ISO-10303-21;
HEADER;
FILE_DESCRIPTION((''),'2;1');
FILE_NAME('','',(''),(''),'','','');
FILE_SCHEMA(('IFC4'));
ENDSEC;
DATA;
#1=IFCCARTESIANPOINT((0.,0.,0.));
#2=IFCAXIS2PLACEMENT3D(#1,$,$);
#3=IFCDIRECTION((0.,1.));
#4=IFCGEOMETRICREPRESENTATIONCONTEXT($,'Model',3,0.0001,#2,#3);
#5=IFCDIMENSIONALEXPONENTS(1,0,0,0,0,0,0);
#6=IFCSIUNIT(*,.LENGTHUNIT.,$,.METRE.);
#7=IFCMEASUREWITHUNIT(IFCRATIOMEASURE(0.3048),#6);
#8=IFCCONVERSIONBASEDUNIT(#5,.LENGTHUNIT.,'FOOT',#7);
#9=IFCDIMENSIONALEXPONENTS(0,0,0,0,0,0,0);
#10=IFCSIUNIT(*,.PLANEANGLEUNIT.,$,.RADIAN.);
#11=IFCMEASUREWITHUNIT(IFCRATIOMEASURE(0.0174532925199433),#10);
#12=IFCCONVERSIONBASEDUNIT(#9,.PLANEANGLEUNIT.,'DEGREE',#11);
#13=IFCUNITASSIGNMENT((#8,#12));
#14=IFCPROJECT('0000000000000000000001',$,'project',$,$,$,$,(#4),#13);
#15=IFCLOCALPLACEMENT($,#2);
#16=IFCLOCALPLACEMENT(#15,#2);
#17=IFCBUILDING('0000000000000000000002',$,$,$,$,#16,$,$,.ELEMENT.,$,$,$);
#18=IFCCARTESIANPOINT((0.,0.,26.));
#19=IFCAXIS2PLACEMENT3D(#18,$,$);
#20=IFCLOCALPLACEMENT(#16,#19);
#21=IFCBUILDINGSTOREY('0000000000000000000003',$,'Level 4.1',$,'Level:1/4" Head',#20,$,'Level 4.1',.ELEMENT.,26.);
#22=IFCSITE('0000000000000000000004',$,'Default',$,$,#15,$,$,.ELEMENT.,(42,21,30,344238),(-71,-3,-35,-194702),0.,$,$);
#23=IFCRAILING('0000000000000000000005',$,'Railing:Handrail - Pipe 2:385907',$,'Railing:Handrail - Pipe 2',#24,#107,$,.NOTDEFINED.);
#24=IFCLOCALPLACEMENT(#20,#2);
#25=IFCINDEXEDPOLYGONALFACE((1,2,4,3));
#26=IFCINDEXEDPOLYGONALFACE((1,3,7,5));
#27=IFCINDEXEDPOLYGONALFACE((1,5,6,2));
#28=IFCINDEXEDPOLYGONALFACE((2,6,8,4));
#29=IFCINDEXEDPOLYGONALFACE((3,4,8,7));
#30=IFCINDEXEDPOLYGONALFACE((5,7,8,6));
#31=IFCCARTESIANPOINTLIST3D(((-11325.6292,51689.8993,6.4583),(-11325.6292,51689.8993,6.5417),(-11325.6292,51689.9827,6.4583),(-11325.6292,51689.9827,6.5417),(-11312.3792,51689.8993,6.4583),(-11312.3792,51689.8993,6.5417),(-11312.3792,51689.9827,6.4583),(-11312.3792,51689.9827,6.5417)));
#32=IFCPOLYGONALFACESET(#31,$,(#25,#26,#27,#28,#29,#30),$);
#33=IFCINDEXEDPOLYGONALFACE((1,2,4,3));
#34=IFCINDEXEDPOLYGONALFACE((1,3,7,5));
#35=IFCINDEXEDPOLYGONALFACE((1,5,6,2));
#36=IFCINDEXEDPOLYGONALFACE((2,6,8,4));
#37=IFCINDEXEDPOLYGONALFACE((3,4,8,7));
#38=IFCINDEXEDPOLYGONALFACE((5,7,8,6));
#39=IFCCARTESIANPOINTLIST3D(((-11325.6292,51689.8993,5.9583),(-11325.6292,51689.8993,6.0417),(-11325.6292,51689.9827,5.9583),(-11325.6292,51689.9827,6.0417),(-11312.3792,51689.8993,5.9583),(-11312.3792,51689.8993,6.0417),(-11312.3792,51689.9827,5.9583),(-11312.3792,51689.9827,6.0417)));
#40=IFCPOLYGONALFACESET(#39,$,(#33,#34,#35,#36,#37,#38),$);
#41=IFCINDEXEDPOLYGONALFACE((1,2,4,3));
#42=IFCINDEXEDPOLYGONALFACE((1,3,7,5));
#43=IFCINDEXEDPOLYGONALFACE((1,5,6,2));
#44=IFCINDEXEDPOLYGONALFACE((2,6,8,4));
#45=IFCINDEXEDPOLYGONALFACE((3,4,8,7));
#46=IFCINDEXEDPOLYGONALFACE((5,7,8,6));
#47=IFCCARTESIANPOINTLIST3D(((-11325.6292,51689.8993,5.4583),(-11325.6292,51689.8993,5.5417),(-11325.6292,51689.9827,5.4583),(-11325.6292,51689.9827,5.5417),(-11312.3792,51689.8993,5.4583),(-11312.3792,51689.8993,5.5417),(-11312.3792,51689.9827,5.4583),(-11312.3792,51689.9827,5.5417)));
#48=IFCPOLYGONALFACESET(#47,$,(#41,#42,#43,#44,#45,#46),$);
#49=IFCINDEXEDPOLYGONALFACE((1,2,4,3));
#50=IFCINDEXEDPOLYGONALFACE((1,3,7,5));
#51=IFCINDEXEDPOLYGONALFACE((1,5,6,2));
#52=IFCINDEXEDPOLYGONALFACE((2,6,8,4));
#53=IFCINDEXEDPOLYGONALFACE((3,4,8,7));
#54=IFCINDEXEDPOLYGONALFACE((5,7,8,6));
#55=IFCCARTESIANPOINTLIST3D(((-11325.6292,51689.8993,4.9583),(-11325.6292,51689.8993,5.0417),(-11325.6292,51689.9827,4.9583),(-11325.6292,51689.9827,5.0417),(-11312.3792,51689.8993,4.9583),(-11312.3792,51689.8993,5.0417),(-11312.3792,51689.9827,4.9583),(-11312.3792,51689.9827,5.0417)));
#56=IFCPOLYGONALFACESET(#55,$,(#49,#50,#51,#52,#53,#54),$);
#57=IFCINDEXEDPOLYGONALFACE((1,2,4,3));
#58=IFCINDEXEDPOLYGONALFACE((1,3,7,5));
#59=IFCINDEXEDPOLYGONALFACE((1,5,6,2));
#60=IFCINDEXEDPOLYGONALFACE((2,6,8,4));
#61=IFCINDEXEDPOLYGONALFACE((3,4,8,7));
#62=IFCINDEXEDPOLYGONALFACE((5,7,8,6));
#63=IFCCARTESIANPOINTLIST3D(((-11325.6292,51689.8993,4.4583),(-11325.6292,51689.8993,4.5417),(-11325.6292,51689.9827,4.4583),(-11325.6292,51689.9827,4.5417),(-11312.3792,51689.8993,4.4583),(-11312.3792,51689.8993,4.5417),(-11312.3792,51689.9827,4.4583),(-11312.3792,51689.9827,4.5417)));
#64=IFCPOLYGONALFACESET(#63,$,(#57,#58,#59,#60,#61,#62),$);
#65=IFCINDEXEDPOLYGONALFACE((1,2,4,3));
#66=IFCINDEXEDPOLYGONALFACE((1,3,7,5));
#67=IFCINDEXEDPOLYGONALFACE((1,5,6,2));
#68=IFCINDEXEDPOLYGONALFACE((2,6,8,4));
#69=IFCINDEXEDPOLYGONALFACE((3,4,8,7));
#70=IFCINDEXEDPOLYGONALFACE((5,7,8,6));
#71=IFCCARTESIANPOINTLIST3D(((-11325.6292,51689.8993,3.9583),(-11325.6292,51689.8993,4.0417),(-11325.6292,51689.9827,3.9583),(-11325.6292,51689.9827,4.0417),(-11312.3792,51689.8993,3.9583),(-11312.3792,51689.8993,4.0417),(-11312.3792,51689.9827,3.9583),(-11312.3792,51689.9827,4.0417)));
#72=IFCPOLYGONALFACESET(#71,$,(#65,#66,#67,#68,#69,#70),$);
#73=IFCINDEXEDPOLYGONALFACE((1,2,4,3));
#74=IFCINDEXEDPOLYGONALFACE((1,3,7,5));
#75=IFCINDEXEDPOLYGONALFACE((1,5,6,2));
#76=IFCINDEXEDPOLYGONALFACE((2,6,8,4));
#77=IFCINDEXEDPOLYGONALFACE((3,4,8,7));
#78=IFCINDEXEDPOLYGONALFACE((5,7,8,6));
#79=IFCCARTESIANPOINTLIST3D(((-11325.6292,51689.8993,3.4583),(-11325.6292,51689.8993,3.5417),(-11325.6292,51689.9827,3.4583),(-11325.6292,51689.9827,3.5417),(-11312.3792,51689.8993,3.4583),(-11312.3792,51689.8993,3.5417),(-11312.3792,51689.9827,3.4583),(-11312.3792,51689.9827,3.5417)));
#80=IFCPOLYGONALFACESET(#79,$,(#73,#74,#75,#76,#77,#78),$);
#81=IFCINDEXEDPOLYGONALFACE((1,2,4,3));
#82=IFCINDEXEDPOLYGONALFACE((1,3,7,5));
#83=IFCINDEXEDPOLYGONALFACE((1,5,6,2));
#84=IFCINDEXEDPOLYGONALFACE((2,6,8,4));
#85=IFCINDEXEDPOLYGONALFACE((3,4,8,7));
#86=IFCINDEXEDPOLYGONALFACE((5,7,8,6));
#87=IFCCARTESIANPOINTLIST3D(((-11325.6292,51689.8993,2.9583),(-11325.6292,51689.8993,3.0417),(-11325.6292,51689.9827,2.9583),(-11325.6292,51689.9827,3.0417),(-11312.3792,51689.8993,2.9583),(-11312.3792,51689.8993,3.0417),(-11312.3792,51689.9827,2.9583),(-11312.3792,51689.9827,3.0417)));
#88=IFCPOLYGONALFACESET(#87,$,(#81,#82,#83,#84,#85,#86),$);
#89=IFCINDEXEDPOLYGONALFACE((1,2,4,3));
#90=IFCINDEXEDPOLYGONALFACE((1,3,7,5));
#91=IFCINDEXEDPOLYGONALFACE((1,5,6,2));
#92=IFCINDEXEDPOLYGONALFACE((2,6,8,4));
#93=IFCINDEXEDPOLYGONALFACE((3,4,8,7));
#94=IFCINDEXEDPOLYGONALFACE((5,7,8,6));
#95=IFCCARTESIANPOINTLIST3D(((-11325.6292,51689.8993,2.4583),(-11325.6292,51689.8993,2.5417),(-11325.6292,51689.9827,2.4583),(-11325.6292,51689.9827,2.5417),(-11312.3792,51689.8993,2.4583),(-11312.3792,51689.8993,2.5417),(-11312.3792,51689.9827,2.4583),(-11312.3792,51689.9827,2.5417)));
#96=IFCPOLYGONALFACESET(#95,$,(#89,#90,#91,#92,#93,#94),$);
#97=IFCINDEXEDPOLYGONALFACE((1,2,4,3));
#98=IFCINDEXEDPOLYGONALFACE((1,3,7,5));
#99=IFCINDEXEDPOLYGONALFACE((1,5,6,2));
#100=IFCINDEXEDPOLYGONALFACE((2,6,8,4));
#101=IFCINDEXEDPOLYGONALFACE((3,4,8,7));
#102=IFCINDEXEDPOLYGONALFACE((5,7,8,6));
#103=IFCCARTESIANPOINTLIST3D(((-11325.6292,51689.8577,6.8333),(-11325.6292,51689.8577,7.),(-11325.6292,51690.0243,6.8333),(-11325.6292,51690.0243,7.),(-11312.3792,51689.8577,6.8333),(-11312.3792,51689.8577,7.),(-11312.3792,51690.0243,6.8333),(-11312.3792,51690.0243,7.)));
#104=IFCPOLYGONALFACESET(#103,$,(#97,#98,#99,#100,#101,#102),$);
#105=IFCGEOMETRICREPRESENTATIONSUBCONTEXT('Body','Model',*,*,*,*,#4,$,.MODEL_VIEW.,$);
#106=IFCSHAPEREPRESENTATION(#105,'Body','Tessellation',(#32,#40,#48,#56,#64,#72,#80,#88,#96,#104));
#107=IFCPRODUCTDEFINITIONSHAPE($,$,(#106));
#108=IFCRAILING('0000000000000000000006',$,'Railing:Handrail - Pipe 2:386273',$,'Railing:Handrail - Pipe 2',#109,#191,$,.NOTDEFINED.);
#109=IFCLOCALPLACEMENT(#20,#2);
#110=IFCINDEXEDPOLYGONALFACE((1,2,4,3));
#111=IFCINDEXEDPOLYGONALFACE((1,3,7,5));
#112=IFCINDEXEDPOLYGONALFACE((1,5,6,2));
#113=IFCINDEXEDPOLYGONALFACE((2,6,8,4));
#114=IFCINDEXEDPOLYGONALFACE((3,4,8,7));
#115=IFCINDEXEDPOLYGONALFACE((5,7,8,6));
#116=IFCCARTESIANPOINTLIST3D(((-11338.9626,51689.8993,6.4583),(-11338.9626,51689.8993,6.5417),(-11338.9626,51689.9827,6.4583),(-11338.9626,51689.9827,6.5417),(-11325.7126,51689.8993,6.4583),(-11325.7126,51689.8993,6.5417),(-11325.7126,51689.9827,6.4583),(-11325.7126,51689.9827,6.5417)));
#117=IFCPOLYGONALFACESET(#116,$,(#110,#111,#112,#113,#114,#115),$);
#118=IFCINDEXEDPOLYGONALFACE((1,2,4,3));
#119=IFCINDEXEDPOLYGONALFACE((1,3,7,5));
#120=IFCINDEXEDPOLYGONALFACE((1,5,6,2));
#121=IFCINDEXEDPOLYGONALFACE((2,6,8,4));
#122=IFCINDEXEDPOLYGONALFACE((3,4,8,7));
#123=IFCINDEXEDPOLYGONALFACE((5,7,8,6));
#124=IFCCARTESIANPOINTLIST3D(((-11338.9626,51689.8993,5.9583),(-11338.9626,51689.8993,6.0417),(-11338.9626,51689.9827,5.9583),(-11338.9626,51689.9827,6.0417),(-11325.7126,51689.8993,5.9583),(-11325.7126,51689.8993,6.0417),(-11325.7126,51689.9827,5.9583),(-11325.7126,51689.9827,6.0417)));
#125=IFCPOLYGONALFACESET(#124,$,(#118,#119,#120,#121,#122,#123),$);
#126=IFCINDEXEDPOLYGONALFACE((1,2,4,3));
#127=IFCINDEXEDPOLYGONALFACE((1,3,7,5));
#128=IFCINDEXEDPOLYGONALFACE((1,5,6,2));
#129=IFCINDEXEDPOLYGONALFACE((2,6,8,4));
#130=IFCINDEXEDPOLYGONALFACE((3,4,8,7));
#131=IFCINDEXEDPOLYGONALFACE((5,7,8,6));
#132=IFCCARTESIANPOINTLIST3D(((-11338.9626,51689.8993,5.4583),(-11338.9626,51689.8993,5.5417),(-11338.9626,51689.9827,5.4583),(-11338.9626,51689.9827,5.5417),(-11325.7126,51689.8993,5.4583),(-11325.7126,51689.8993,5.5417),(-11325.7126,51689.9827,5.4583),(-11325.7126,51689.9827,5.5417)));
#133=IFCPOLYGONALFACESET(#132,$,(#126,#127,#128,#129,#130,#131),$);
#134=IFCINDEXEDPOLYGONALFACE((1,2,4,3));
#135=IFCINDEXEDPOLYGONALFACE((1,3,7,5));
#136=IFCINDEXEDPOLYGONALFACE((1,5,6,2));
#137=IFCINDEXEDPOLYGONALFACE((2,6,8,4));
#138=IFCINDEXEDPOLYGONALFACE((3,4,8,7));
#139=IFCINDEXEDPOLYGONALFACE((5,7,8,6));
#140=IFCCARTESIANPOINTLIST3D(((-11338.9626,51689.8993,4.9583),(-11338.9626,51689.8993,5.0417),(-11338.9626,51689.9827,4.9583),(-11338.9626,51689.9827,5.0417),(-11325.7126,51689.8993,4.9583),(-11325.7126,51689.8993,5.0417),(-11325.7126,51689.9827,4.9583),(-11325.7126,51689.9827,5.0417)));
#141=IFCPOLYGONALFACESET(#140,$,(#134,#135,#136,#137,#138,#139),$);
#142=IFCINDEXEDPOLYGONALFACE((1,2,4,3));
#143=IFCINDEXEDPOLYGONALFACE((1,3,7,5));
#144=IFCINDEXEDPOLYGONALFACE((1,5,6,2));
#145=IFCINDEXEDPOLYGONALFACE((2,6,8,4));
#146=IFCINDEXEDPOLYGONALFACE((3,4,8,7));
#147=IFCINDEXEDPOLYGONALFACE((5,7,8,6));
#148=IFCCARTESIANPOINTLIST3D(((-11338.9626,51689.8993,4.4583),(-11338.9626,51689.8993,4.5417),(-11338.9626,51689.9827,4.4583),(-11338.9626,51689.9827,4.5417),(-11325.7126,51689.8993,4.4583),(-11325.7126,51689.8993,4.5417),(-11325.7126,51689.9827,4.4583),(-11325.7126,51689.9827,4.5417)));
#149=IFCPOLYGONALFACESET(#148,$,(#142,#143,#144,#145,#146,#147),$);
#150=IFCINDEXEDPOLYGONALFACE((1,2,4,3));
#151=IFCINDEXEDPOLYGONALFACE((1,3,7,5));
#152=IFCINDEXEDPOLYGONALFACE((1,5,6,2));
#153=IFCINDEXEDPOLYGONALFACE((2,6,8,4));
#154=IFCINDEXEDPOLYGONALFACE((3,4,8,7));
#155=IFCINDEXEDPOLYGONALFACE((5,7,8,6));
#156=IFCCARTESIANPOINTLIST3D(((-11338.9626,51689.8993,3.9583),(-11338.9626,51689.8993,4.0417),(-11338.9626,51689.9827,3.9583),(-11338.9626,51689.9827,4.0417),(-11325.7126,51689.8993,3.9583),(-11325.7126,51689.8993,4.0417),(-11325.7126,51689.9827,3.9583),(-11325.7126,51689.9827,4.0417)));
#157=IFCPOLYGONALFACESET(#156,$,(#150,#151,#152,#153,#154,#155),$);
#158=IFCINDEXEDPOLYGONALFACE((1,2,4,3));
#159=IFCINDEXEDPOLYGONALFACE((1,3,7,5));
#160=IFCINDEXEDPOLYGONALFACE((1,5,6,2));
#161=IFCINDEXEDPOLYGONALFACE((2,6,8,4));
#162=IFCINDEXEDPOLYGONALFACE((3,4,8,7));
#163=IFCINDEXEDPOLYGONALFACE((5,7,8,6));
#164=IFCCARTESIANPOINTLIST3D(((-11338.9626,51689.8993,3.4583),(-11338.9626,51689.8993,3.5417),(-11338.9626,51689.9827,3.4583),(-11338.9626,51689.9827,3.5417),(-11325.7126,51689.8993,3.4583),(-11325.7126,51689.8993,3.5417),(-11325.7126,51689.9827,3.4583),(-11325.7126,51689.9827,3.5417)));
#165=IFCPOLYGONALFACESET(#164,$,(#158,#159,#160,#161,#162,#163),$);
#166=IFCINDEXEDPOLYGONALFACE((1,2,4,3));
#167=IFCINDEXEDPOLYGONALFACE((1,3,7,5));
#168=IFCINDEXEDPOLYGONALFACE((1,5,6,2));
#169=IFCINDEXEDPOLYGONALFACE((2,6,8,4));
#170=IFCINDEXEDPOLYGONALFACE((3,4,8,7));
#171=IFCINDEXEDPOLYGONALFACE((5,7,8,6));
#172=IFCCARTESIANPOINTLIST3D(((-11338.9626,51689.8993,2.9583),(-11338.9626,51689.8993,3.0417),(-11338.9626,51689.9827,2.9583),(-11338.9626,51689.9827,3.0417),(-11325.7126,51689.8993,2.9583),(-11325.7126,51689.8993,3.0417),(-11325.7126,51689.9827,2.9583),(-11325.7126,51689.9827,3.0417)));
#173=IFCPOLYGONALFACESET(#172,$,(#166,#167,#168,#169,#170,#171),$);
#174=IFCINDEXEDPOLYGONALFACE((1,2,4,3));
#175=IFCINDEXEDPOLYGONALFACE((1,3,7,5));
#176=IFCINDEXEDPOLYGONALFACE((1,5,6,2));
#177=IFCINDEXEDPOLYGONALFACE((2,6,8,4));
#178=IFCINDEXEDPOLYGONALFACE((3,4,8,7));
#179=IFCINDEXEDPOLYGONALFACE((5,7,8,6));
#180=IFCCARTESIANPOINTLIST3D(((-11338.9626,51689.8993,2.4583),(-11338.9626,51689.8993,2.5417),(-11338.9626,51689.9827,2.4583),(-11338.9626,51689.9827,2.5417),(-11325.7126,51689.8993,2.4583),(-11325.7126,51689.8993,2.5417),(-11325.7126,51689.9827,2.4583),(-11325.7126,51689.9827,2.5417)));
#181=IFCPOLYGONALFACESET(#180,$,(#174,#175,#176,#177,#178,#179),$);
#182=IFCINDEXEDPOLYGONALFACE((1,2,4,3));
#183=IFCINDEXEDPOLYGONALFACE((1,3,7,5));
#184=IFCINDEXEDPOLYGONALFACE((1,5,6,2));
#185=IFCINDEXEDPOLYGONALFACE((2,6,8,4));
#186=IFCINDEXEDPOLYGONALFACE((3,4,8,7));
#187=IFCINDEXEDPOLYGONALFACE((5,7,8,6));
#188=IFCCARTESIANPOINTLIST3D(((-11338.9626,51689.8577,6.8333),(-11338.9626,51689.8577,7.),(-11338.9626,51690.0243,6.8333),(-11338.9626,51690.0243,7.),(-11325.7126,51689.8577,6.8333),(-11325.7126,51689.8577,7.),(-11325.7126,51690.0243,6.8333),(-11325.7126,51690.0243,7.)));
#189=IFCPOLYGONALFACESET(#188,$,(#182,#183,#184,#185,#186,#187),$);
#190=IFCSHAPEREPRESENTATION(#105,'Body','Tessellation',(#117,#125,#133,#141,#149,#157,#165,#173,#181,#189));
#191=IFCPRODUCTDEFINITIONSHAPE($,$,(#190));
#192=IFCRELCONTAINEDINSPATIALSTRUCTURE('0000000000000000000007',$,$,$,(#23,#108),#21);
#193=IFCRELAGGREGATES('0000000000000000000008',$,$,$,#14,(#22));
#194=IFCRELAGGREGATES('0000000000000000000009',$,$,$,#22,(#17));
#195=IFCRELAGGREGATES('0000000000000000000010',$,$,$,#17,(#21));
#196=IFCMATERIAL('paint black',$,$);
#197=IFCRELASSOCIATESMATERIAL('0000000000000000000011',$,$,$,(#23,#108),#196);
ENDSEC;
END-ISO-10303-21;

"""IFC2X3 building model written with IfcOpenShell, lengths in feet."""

from ifc_helpers import new_model, entity, si_unit, converted_unit, direction, frame, frame_2d, origin, place, context, subcontext, project, spatial, rectangle, extrude, material, element, save


model = new_model("IFC2X3")

# Units and contexts
model_context = context("Model", 3, precision=0.0001, world=origin(), true_north=direction((0.0, 1.0)))
body_context = subcontext(model_context, "Body", "Model", "MODEL_VIEW")
ifc_project = project(units=[converted_unit("LENGTHUNIT", "FOOT", entity("IfcRatioMeasure", 0.3048), si_unit("LENGTHUNIT", "METRE"), dimensions=[1, 0, 0, 0, 0, 0, 0]), converted_unit("PLANEANGLEUNIT", "DEGREE", entity("IfcRatioMeasure", 0.0174532925199433), si_unit("PLANEANGLEUNIT", "RADIAN"), dimensions=[0, 0, 0, 0, 0, 0, 0])], contexts=[model_context])

# Site, building, storey
site_placement = place(None, origin())
site = spatial("IfcSite", under=ifc_project, at=site_placement, Name="Default", CompositionType="ELEMENT", RefLatitude=(42, 21, 30, 344238), RefLongitude=(-71, -3, -35, -194702), RefElevation=0.0)
building_placement = place(site_placement, origin())
building = spatial("IfcBuilding", under=site, at=building_placement, CompositionType="ELEMENT")
storey_placement = place(building_placement, frame((0.0, 0.0, 26.0)))
storey = spatial("IfcBuildingStorey", under=building, at=storey_placement, Name="Level 4.1", ObjectType="Level:1/4\" Head", LongName="Level 4.1", CompositionType="ELEMENT", Elevation=26.0)

# Railings
ifc_material_1 = material(Name="paint black")
railing_1_placement = place(storey_placement, origin())
element("IfcRailing", 1, at=railing_1_placement, inside=storey, material=ifc_material_1, Name="Railing:Handrail - Pipe 2:385907", ObjectType="Railing:Handrail - Pipe 2", PredefinedType="NOTDEFINED", context=body_context, shape_type="SweptSolid", body=[
    extrude(rectangle(XDim=13.25, YDim=0.0833, at=frame_2d((0.0, 0.0), x_axis=(1.0, 0.0))), frame((-11319.0042, 51689.941, 6.4583), z_axis=(0.0, 0.0, 1.0), x_axis=(-1.0, 0.0, 0.0)), (0.0, 0.0, 1.0), 0.0833),
    extrude(rectangle(XDim=13.25, YDim=0.0833, at=frame_2d((0.0, 0.0), x_axis=(1.0, 0.0))), frame((-11319.0042, 51689.941, 5.9583), z_axis=(0.0, 0.0, 1.0), x_axis=(-1.0, 0.0, 0.0)), (0.0, 0.0, 1.0), 0.0833),
    extrude(rectangle(XDim=13.25, YDim=0.0833, at=frame_2d((0.0, 0.0), x_axis=(1.0, 0.0))), frame((-11319.0042, 51689.941, 5.4583), z_axis=(0.0, 0.0, 1.0), x_axis=(-1.0, 0.0, 0.0)), (0.0, 0.0, 1.0), 0.0833),
    extrude(rectangle(XDim=13.25, YDim=0.0833, at=frame_2d((0.0, 0.0), x_axis=(1.0, 0.0))), frame((-11319.0042, 51689.941, 4.9583), z_axis=(0.0, 0.0, 1.0), x_axis=(-1.0, 0.0, 0.0)), (0.0, 0.0, 1.0), 0.0833),
    extrude(rectangle(XDim=13.25, YDim=0.0833, at=frame_2d((0.0, 0.0), x_axis=(1.0, 0.0))), frame((-11319.0042, 51689.941, 4.4583), z_axis=(0.0, 0.0, 1.0), x_axis=(-1.0, 0.0, 0.0)), (0.0, 0.0, 1.0), 0.0833),
    extrude(rectangle(XDim=13.25, YDim=0.0833, at=frame_2d((0.0, 0.0), x_axis=(1.0, 0.0))), frame((-11319.0042, 51689.941, 3.9583), z_axis=(0.0, 0.0, 1.0), x_axis=(-1.0, 0.0, 0.0)), (0.0, 0.0, 1.0), 0.0833),
    extrude(rectangle(XDim=13.25, YDim=0.0833, at=frame_2d((0.0, 0.0), x_axis=(1.0, 0.0))), frame((-11319.0042, 51689.941, 3.4583), z_axis=(0.0, 0.0, 1.0), x_axis=(-1.0, 0.0, 0.0)), (0.0, 0.0, 1.0), 0.0833),
    extrude(rectangle(XDim=13.25, YDim=0.0833, at=frame_2d((0.0, 0.0), x_axis=(1.0, 0.0))), frame((-11319.0042, 51689.941, 2.9583), z_axis=(0.0, 0.0, 1.0), x_axis=(-1.0, 0.0, 0.0)), (0.0, 0.0, 1.0), 0.0833),
    extrude(rectangle(XDim=13.25, YDim=0.0833, at=frame_2d((0.0, 0.0), x_axis=(1.0, 0.0))), frame((-11319.0042, 51689.941, 2.4583), z_axis=(0.0, 0.0, 1.0), x_axis=(-1.0, 0.0, 0.0)), (0.0, 0.0, 1.0), 0.0833),
    extrude(rectangle(XDim=13.25, YDim=0.1667, at=frame_2d((0.0, 0.0), x_axis=(1.0, 0.0))), frame((-11319.0042, 51689.941, 6.8333), z_axis=(0.0, 0.0, 1.0), x_axis=(-1.0, 0.0, 0.0)), (0.0, 0.0, 1.0), 0.1667),
])
railing_2_placement = place(storey_placement, origin())
element("IfcRailing", 2, at=railing_2_placement, inside=storey, material=ifc_material_1, Name="Railing:Handrail - Pipe 2:386273", ObjectType="Railing:Handrail - Pipe 2", PredefinedType="NOTDEFINED", context=body_context, shape_type="SweptSolid", body=[
    extrude(rectangle(XDim=13.25, YDim=0.0833, at=frame_2d((0.0, 0.0), x_axis=(1.0, 0.0))), frame((-11332.3376, 51689.941, 6.4583), z_axis=(0.0, 0.0, 1.0), x_axis=(-1.0, 0.0, 0.0)), (0.0, 0.0, 1.0), 0.0833),
    extrude(rectangle(XDim=13.25, YDim=0.0833, at=frame_2d((0.0, 0.0), x_axis=(1.0, 0.0))), frame((-11332.3376, 51689.941, 5.9583), z_axis=(0.0, 0.0, 1.0), x_axis=(-1.0, 0.0, 0.0)), (0.0, 0.0, 1.0), 0.0833),
    extrude(rectangle(XDim=13.25, YDim=0.0833, at=frame_2d((0.0, 0.0), x_axis=(1.0, 0.0))), frame((-11332.3376, 51689.941, 5.4583), z_axis=(0.0, 0.0, 1.0), x_axis=(-1.0, 0.0, 0.0)), (0.0, 0.0, 1.0), 0.0833),
    extrude(rectangle(XDim=13.25, YDim=0.0833, at=frame_2d((0.0, 0.0), x_axis=(1.0, 0.0))), frame((-11332.3376, 51689.941, 4.9583), z_axis=(0.0, 0.0, 1.0), x_axis=(-1.0, 0.0, 0.0)), (0.0, 0.0, 1.0), 0.0833),
    extrude(rectangle(XDim=13.25, YDim=0.0833, at=frame_2d((0.0, 0.0), x_axis=(1.0, 0.0))), frame((-11332.3376, 51689.941, 4.4583), z_axis=(0.0, 0.0, 1.0), x_axis=(-1.0, 0.0, 0.0)), (0.0, 0.0, 1.0), 0.0833),
    extrude(rectangle(XDim=13.25, YDim=0.0833, at=frame_2d((0.0, 0.0), x_axis=(1.0, 0.0))), frame((-11332.3376, 51689.941, 3.9583), z_axis=(0.0, 0.0, 1.0), x_axis=(-1.0, 0.0, 0.0)), (0.0, 0.0, 1.0), 0.0833),
    extrude(rectangle(XDim=13.25, YDim=0.0833, at=frame_2d((0.0, 0.0), x_axis=(1.0, 0.0))), frame((-11332.3376, 51689.941, 3.4583), z_axis=(0.0, 0.0, 1.0), x_axis=(-1.0, 0.0, 0.0)), (0.0, 0.0, 1.0), 0.0833),
    extrude(rectangle(XDim=13.25, YDim=0.0833, at=frame_2d((0.0, 0.0), x_axis=(1.0, 0.0))), frame((-11332.3376, 51689.941, 2.9583), z_axis=(0.0, 0.0, 1.0), x_axis=(-1.0, 0.0, 0.0)), (0.0, 0.0, 1.0), 0.0833),
    extrude(rectangle(XDim=13.25, YDim=0.0833, at=frame_2d((0.0, 0.0), x_axis=(1.0, 0.0))), frame((-11332.3376, 51689.941, 2.4583), z_axis=(0.0, 0.0, 1.0), x_axis=(-1.0, 0.0, 0.0)), (0.0, 0.0, 1.0), 0.0833),
    extrude(rectangle(XDim=13.25, YDim=0.1667, at=frame_2d((0.0, 0.0), x_axis=(1.0, 0.0))), frame((-11332.3376, 51689.941, 6.8333), z_axis=(0.0, 0.0, 1.0), x_axis=(-1.0, 0.0, 0.0)), (0.0, 0.0, 1.0), 0.1667),
])

save(model, "model.ifc")
